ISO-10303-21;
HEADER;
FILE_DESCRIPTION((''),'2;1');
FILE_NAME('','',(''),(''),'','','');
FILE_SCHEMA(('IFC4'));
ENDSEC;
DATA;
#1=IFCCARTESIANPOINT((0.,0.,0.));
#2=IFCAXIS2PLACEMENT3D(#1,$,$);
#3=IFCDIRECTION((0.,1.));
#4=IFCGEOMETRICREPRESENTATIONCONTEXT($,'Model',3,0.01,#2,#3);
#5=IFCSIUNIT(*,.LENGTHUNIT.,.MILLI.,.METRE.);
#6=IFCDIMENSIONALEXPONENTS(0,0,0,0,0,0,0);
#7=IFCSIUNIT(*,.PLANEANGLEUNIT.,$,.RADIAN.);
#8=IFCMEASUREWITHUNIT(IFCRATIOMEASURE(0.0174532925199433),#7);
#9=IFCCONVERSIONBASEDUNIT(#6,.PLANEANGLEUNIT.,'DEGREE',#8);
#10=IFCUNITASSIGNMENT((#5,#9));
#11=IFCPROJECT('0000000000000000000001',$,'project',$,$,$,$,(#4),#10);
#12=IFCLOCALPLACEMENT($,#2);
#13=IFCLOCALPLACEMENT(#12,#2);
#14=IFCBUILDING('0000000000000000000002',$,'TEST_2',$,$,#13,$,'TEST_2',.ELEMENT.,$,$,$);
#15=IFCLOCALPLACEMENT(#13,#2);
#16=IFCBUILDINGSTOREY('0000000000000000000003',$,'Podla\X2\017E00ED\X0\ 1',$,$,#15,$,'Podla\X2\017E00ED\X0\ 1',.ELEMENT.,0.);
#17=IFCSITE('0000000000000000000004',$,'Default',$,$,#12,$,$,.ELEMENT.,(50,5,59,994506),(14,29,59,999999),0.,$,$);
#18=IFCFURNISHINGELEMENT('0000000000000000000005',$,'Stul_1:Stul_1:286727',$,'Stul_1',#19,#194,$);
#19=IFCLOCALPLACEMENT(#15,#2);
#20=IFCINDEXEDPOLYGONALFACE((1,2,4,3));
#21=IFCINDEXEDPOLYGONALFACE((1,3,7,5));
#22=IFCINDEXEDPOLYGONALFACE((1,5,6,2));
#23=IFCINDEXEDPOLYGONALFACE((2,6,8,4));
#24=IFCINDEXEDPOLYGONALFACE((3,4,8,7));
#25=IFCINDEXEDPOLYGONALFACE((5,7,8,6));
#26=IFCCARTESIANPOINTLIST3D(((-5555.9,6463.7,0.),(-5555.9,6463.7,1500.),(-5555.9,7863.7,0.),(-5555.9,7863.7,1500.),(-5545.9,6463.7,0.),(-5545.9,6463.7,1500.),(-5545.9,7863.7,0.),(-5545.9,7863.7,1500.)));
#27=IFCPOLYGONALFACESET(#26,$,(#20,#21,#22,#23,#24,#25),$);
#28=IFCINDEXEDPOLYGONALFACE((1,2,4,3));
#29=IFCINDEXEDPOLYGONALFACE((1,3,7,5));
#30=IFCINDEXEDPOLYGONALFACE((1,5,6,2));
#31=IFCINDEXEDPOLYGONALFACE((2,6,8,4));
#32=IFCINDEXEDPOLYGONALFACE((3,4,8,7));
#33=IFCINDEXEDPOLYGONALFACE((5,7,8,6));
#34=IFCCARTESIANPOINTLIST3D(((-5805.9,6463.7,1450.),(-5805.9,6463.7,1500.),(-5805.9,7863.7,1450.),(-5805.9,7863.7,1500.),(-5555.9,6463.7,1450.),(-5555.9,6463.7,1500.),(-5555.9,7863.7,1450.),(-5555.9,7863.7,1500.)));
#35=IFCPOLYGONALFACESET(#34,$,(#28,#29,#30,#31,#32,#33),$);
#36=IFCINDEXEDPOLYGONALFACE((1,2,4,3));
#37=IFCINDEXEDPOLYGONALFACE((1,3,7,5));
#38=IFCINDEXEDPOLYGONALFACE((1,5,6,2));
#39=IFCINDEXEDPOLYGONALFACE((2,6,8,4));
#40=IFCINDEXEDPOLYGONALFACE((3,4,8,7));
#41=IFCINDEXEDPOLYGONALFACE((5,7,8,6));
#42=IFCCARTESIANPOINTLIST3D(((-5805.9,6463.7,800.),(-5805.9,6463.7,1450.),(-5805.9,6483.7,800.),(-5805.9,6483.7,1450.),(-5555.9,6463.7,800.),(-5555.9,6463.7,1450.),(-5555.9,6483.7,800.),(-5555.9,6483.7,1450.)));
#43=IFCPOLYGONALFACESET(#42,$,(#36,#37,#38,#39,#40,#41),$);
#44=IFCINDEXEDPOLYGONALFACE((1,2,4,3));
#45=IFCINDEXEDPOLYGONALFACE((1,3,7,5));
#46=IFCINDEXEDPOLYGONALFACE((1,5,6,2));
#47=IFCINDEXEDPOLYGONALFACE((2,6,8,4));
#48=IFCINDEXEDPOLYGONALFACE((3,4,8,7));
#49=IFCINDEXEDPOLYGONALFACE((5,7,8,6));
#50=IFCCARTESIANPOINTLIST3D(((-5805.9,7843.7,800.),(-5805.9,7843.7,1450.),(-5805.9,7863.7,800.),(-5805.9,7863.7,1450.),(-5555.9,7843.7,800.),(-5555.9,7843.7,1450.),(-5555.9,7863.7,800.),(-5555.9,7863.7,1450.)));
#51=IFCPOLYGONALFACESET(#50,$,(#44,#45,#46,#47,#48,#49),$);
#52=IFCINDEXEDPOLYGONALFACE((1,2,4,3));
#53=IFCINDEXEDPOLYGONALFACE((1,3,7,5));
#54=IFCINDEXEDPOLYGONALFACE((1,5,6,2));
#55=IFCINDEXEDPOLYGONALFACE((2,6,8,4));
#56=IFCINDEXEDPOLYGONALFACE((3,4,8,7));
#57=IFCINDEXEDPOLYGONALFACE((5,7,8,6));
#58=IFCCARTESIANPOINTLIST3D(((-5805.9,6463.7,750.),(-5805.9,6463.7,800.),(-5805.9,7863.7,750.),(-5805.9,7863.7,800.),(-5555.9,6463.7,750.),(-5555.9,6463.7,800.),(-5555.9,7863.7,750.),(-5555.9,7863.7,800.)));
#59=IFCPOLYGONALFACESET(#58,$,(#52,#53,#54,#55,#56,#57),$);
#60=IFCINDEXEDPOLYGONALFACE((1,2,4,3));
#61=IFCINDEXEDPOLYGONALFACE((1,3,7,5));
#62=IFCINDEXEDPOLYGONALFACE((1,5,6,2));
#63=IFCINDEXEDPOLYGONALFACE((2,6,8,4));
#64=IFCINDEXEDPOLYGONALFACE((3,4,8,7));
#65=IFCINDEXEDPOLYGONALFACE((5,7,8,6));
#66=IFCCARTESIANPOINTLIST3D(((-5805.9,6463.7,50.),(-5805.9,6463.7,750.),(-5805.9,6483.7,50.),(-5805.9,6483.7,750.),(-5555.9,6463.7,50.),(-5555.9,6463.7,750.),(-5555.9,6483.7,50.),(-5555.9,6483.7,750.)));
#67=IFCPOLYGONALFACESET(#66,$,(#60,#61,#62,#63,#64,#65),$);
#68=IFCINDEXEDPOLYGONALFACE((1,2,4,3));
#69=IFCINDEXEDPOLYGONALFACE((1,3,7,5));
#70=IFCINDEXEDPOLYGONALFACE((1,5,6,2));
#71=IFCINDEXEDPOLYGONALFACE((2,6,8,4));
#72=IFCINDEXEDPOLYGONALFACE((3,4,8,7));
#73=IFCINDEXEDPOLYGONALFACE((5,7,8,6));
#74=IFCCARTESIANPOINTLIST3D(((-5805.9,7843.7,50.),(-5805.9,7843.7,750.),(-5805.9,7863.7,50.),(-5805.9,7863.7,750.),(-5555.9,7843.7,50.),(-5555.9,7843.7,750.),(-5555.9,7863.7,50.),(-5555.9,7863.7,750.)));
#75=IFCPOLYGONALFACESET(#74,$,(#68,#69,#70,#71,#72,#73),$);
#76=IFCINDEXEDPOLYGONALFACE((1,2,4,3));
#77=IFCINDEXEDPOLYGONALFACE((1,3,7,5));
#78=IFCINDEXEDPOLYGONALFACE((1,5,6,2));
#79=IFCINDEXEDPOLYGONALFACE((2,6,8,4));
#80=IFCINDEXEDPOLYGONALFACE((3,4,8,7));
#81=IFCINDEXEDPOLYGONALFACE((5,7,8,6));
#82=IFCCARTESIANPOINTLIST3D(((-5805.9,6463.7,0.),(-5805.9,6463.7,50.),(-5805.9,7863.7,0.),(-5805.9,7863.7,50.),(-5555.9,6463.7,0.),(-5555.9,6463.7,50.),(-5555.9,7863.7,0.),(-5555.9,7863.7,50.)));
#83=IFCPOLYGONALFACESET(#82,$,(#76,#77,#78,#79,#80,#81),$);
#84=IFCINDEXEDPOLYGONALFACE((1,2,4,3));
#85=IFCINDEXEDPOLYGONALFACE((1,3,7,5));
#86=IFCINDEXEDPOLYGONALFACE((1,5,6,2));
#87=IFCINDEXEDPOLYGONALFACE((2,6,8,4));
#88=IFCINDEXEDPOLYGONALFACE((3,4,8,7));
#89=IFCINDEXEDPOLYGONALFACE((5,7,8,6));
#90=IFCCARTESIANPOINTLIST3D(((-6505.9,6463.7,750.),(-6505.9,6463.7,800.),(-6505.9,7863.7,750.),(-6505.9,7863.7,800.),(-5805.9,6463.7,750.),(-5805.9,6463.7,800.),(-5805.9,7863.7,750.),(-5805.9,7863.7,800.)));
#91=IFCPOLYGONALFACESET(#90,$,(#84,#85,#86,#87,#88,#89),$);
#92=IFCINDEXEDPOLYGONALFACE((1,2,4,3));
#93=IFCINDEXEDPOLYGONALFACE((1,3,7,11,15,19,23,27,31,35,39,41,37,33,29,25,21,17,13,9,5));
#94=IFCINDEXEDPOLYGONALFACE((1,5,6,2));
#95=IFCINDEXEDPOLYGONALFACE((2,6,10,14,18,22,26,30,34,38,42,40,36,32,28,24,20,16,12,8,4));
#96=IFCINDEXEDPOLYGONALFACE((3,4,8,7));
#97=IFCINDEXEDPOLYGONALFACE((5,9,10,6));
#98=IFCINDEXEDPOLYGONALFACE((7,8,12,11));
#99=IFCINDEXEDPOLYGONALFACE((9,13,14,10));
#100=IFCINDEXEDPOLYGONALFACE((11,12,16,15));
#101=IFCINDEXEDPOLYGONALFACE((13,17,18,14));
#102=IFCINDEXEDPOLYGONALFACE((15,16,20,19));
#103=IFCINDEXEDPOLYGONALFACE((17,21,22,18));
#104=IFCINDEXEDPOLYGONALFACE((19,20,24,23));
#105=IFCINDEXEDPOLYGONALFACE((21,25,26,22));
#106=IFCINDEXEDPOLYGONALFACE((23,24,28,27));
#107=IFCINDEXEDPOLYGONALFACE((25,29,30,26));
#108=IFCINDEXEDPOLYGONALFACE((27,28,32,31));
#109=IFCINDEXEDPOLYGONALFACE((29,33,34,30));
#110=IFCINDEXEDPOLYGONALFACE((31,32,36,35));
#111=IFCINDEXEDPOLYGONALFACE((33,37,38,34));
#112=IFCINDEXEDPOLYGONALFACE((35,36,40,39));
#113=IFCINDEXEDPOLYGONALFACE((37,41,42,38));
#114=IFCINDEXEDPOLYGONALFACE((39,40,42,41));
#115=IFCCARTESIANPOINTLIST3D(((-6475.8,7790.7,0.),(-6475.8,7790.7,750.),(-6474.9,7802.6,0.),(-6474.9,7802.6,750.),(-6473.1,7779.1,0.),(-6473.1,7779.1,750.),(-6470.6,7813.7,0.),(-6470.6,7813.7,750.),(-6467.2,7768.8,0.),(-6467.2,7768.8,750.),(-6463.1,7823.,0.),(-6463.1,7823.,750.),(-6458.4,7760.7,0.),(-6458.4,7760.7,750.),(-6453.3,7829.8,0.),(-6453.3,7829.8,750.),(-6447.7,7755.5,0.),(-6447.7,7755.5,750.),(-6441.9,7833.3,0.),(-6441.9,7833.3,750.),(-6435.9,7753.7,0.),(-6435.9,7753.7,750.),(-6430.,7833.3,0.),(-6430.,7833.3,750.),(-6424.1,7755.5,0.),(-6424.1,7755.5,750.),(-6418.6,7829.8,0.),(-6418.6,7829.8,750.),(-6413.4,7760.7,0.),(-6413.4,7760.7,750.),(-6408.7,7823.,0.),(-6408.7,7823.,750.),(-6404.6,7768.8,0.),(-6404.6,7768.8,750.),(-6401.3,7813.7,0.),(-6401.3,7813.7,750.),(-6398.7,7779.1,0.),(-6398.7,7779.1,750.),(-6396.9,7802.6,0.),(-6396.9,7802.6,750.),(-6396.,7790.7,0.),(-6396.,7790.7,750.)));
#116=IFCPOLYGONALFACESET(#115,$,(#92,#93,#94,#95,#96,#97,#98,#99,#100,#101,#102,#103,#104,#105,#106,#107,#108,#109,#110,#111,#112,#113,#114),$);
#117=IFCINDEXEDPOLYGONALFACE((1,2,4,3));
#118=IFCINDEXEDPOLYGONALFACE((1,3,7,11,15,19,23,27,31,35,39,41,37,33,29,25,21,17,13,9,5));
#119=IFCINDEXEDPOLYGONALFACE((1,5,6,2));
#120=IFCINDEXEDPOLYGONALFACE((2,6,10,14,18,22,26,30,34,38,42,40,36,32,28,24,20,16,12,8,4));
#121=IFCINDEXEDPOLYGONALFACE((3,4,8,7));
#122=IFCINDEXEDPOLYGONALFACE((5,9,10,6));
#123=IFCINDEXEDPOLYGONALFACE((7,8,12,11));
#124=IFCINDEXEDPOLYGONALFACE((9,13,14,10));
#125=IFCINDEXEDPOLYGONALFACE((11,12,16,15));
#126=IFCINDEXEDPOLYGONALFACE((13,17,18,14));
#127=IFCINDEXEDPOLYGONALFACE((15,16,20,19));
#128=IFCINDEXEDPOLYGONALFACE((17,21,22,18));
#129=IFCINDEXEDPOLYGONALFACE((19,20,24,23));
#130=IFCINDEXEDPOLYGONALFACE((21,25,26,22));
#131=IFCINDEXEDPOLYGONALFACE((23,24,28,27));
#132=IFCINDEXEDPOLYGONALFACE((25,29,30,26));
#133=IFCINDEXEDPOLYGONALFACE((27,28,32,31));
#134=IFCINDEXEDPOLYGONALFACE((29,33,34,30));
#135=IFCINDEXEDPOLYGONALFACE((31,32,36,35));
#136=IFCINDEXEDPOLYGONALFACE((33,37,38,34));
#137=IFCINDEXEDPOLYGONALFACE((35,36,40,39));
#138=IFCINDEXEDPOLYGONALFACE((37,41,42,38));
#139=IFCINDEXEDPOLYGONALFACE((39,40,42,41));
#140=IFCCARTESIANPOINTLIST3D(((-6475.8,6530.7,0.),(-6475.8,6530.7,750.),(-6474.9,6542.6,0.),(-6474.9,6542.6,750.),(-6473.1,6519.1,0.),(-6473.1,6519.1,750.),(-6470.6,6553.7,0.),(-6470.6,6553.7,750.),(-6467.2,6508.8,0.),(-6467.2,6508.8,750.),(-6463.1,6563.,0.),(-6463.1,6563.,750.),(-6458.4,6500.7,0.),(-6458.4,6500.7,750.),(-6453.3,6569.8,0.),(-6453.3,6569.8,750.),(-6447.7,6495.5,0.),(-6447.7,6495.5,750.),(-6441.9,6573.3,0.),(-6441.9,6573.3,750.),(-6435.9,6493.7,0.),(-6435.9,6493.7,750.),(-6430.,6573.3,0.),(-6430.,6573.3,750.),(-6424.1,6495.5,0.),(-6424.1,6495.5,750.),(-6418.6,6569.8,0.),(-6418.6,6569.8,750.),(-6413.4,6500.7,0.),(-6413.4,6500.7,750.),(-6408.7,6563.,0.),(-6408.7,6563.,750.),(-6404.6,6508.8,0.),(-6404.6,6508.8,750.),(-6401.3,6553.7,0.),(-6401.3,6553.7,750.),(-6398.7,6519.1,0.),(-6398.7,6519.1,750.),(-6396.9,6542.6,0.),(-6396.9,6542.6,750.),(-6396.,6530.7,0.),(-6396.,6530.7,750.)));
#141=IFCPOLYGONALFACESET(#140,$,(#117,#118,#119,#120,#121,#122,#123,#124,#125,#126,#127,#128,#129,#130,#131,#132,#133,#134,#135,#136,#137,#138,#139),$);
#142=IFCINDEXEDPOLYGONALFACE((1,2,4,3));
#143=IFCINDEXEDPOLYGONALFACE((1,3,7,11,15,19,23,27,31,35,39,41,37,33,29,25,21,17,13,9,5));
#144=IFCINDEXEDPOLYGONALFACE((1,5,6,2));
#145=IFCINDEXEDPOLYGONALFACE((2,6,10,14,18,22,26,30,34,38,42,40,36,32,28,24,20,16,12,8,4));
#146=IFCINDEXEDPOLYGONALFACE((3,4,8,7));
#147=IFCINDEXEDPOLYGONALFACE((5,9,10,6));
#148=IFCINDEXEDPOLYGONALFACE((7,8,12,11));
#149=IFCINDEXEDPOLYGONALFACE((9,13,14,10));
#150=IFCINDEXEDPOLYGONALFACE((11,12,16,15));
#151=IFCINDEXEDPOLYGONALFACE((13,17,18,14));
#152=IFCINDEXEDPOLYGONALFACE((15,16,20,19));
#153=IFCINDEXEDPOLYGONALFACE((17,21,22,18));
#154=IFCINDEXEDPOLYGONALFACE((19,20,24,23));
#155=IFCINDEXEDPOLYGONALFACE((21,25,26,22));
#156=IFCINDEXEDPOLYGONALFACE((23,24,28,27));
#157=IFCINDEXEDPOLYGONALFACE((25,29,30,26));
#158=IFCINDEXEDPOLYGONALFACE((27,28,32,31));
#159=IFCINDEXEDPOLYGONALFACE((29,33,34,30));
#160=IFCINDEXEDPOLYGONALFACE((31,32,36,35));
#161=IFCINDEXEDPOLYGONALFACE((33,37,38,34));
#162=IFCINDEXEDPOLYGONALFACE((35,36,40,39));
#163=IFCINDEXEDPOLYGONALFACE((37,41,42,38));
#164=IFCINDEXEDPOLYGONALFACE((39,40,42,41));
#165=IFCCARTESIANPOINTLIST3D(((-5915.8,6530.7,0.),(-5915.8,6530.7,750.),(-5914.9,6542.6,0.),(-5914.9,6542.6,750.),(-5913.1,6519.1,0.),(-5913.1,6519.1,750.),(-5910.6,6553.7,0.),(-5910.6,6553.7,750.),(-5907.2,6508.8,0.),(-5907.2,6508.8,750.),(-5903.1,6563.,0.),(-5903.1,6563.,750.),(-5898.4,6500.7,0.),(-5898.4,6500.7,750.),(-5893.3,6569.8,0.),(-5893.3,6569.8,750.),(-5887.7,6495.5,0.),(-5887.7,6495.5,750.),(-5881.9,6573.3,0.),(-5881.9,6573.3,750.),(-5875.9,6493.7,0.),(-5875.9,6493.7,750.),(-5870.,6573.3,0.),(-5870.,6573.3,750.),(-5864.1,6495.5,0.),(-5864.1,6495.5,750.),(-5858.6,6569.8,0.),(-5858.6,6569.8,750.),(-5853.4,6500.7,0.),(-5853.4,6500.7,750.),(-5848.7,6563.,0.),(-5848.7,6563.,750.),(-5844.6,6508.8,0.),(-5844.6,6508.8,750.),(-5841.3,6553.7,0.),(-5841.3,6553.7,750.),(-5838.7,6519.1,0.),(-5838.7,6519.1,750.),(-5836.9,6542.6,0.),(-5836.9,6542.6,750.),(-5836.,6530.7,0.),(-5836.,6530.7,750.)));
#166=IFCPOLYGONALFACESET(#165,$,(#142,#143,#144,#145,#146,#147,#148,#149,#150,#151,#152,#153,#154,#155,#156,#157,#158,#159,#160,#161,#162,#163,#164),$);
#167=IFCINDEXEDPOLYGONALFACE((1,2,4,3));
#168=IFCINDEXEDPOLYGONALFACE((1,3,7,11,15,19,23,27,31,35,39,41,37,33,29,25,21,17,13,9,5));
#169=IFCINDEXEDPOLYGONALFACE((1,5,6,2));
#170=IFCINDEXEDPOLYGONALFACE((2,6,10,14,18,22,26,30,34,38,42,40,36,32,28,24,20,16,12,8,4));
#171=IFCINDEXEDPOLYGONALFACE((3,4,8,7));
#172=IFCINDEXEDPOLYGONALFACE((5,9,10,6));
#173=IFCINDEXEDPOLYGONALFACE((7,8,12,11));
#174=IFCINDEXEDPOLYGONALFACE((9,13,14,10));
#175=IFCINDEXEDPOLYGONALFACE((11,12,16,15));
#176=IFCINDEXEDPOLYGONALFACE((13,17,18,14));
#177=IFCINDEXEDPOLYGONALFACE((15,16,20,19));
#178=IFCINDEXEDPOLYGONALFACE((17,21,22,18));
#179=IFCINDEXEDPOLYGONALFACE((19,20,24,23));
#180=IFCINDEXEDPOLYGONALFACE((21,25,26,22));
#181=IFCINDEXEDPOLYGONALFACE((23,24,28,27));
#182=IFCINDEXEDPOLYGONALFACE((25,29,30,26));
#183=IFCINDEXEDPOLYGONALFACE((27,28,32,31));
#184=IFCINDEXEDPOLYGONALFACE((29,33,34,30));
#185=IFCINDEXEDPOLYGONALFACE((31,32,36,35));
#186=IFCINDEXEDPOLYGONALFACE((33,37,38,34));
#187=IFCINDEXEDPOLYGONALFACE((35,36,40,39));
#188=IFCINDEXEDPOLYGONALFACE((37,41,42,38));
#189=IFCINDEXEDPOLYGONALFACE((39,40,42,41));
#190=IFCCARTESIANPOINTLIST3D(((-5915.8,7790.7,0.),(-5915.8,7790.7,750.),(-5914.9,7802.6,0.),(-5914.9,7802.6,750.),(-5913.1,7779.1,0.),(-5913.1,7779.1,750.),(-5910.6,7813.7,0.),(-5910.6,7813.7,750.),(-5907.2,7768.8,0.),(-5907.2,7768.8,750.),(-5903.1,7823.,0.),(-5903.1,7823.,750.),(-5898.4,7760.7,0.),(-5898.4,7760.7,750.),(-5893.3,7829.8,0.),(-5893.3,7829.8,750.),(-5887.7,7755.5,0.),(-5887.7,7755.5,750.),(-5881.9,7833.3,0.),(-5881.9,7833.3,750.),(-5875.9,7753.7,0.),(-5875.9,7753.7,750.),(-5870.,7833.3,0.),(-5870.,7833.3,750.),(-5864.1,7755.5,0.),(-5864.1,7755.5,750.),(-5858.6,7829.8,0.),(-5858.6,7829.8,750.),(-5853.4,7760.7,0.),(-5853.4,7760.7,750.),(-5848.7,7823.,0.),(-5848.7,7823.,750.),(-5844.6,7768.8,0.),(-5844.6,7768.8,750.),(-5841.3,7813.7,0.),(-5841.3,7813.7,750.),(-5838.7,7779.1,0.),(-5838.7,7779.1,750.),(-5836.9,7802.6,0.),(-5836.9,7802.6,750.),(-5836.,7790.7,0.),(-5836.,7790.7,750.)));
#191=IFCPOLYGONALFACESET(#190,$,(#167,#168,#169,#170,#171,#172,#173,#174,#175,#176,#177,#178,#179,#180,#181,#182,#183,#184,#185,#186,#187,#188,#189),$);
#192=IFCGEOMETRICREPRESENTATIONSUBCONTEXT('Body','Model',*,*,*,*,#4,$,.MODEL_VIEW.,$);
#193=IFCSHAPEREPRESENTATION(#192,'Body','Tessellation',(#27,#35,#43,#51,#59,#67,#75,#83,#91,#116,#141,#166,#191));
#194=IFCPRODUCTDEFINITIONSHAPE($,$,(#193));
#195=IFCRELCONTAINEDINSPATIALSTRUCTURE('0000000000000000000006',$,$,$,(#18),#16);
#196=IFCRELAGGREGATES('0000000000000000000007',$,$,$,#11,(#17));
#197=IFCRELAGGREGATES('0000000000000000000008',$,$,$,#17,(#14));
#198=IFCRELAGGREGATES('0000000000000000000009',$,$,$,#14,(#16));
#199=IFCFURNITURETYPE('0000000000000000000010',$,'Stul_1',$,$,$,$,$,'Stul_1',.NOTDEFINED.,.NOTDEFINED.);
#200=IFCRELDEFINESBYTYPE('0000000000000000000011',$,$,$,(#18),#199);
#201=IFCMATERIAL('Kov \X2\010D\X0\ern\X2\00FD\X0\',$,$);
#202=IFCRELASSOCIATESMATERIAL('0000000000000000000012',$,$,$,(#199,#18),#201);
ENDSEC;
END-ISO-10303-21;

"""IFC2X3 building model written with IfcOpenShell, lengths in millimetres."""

from ifc_helpers import new_model, entity, si_unit, converted_unit, direction, frame, frame_2d, origin, origin_2d_with_axis, place, context, subcontext, project, spatial, rectangle, circle, extrude, source, transform, mapped, material, type_object, type_shapes, element, save


model = new_model("IFC2X3")

# Units and contexts
model_context = context("Model", 3, precision=0.01, world=origin(), true_north=direction((0.0, 1.0)))
body_context = subcontext(model_context, "Body", "Model", "MODEL_VIEW")
ifc_project = project(units=[si_unit("LENGTHUNIT", "METRE", prefix="MILLI"), converted_unit("PLANEANGLEUNIT", "DEGREE", entity("IfcRatioMeasure", 0.0174532925199433), si_unit("PLANEANGLEUNIT", "RADIAN"), dimensions=[0, 0, 0, 0, 0, 0, 0])], contexts=[model_context])

# Site, building, storey
site_placement = place(None, origin())
site = spatial("IfcSite", under=ifc_project, at=site_placement, Name="Default", CompositionType="ELEMENT", RefLatitude=(50, 5, 59, 994506), RefLongitude=(14, 29, 59, 999999), RefElevation=0.0)
building_placement = place(site_placement, origin())
building = spatial("IfcBuilding", under=site, at=building_placement, Name="TEST_2", LongName="TEST_2", CompositionType="ELEMENT")
storey_placement = place(building_placement, origin())
storey = spatial("IfcBuildingStorey", under=building, at=storey_placement, Name="Podlaží 1", LongName="Podlaží 1", CompositionType="ELEMENT", Elevation=0.0)

# Furnishing element
ifc_material_1 = material(Name="Kov černý")
furniture_type = type_object("IfcFurnitureType", Name="Stul_1", ElementType="Stul_1", material=ifc_material_1)
shared_shape_1 = source(origin(), body_context, "Body", "SweptSolid", [
    extrude(rectangle(XDim=1400.0, YDim=10.0, at=origin_2d_with_axis()), frame((0.0, 605.0, 0.0), z_axis=(0.0, 0.0, 1.0), x_axis=(-1.0, 0.0, 0.0)), (0.0, 0.0, 1.0), 1500.0),
    extrude(rectangle(XDim=1400.0, YDim=250.0, at=frame_2d((0.0, 0.0), x_axis=(1.0, 0.0))), frame((0.0, 475.0, 1450.0), z_axis=(0.0, 0.0, 1.0), x_axis=(-1.0, 0.0, 0.0)), (0.0, 0.0, 1.0), 50.0),
    extrude(rectangle(XDim=20.0, YDim=250.0, at=origin_2d_with_axis()), frame((690.0, 475.0, 800.0), z_axis=(0.0, 0.0, 1.0), x_axis=(-1.0, 0.0, 0.0)), (0.0, 0.0, 1.0), 650.0),
    extrude(rectangle(XDim=20.0, YDim=250.0, at=frame_2d((0.0, 0.0), x_axis=(1.0, 0.0))), frame((-690.0, 475.0, 800.0), z_axis=(0.0, 0.0, 1.0), x_axis=(-1.0, 0.0, 0.0)), (0.0, 0.0, 1.0), 650.0),
    extrude(rectangle(XDim=1400.0, YDim=250.0, at=origin_2d_with_axis()), frame((0.0, 475.0, 750.0), z_axis=(0.0, 0.0, 1.0), x_axis=(-1.0, 0.0, 0.0)), (0.0, 0.0, 1.0), 50.0),
    extrude(rectangle(XDim=20.0, YDim=250.0, at=origin_2d_with_axis()), frame((690.0, 475.0, 50.0), z_axis=(0.0, 0.0, 1.0), x_axis=(-1.0, 0.0, 0.0)), (0.0, 0.0, 1.0), 700.0),
    extrude(rectangle(XDim=20.0, YDim=250.0, at=frame_2d((0.0, 0.0), x_axis=(1.0, 0.0))), frame((-690.0, 475.0, 50.0), z_axis=(0.0, 0.0, 1.0), x_axis=(-1.0, 0.0, 0.0)), (0.0, 0.0, 1.0), 700.0),
    extrude(rectangle(XDim=1400.0, YDim=250.0, at=origin_2d_with_axis()), frame((0.0, 475.0, 0.0), z_axis=(0.0, 0.0, 1.0), x_axis=(-1.0, 0.0, 0.0)), (0.0, 0.0, 1.0), 50.0),
    extrude(rectangle(XDim=1400.0, YDim=700.0, at=origin_2d_with_axis()), frame((0.0, 0.0, 750.0), z_axis=(0.0, 0.0, 1.0), x_axis=(-1.0, 0.0, 0.0)), (0.0, 0.0, 1.0), 50.0),
    extrude(circle(Radius=40.0, at=frame_2d((0.0, 0.0), x_axis=(1.0, 0.0))), frame((-630.0, -280.0, 0.0)), (0.0, 0.0, 1.0), 750.0),
    extrude(circle(Radius=40.0, at=frame_2d((0.0, 0.0), x_axis=(1.0, 0.0))), frame((630.0, -280.0, 0.0)), (0.0, 0.0, 1.0), 750.0),
    extrude(circle(Radius=40.0, at=frame_2d((0.0, 0.0), x_axis=(1.0, 0.0))), frame((630.0, 280.0, 0.0)), (0.0, 0.0, 1.0), 750.0),
    extrude(circle(Radius=40.0, at=frame_2d((0.0, 0.0), x_axis=(1.0, 0.0))), frame((-630.0, 280.0, 0.0)), (0.0, 0.0, 1.0), 750.0),
])
type_shapes(furniture_type, [shared_shape_1])
for number, where, z_axis, x_axis, name in (
    (1, (-6155.9, 7163.7, 0.0), (0.0, 0.0, 1.0), (0.0, -1.0, 0.0), "Stul_1:Stul_1:286727"),
):
    element("IfcFurnishingElement", number, at=place(storey_placement, frame(where, z_axis=z_axis, x_axis=x_axis)), inside=storey, type_object=furniture_type, material=ifc_material_1, Name=name, ObjectType="Stul_1", context=body_context, shape_type="MappedRepresentation", body=[
        mapped(shared_shape_1, transform((0.0, 0.0, 0.0), scale=1.0)),
    ])

save(model, "model.ifc")
